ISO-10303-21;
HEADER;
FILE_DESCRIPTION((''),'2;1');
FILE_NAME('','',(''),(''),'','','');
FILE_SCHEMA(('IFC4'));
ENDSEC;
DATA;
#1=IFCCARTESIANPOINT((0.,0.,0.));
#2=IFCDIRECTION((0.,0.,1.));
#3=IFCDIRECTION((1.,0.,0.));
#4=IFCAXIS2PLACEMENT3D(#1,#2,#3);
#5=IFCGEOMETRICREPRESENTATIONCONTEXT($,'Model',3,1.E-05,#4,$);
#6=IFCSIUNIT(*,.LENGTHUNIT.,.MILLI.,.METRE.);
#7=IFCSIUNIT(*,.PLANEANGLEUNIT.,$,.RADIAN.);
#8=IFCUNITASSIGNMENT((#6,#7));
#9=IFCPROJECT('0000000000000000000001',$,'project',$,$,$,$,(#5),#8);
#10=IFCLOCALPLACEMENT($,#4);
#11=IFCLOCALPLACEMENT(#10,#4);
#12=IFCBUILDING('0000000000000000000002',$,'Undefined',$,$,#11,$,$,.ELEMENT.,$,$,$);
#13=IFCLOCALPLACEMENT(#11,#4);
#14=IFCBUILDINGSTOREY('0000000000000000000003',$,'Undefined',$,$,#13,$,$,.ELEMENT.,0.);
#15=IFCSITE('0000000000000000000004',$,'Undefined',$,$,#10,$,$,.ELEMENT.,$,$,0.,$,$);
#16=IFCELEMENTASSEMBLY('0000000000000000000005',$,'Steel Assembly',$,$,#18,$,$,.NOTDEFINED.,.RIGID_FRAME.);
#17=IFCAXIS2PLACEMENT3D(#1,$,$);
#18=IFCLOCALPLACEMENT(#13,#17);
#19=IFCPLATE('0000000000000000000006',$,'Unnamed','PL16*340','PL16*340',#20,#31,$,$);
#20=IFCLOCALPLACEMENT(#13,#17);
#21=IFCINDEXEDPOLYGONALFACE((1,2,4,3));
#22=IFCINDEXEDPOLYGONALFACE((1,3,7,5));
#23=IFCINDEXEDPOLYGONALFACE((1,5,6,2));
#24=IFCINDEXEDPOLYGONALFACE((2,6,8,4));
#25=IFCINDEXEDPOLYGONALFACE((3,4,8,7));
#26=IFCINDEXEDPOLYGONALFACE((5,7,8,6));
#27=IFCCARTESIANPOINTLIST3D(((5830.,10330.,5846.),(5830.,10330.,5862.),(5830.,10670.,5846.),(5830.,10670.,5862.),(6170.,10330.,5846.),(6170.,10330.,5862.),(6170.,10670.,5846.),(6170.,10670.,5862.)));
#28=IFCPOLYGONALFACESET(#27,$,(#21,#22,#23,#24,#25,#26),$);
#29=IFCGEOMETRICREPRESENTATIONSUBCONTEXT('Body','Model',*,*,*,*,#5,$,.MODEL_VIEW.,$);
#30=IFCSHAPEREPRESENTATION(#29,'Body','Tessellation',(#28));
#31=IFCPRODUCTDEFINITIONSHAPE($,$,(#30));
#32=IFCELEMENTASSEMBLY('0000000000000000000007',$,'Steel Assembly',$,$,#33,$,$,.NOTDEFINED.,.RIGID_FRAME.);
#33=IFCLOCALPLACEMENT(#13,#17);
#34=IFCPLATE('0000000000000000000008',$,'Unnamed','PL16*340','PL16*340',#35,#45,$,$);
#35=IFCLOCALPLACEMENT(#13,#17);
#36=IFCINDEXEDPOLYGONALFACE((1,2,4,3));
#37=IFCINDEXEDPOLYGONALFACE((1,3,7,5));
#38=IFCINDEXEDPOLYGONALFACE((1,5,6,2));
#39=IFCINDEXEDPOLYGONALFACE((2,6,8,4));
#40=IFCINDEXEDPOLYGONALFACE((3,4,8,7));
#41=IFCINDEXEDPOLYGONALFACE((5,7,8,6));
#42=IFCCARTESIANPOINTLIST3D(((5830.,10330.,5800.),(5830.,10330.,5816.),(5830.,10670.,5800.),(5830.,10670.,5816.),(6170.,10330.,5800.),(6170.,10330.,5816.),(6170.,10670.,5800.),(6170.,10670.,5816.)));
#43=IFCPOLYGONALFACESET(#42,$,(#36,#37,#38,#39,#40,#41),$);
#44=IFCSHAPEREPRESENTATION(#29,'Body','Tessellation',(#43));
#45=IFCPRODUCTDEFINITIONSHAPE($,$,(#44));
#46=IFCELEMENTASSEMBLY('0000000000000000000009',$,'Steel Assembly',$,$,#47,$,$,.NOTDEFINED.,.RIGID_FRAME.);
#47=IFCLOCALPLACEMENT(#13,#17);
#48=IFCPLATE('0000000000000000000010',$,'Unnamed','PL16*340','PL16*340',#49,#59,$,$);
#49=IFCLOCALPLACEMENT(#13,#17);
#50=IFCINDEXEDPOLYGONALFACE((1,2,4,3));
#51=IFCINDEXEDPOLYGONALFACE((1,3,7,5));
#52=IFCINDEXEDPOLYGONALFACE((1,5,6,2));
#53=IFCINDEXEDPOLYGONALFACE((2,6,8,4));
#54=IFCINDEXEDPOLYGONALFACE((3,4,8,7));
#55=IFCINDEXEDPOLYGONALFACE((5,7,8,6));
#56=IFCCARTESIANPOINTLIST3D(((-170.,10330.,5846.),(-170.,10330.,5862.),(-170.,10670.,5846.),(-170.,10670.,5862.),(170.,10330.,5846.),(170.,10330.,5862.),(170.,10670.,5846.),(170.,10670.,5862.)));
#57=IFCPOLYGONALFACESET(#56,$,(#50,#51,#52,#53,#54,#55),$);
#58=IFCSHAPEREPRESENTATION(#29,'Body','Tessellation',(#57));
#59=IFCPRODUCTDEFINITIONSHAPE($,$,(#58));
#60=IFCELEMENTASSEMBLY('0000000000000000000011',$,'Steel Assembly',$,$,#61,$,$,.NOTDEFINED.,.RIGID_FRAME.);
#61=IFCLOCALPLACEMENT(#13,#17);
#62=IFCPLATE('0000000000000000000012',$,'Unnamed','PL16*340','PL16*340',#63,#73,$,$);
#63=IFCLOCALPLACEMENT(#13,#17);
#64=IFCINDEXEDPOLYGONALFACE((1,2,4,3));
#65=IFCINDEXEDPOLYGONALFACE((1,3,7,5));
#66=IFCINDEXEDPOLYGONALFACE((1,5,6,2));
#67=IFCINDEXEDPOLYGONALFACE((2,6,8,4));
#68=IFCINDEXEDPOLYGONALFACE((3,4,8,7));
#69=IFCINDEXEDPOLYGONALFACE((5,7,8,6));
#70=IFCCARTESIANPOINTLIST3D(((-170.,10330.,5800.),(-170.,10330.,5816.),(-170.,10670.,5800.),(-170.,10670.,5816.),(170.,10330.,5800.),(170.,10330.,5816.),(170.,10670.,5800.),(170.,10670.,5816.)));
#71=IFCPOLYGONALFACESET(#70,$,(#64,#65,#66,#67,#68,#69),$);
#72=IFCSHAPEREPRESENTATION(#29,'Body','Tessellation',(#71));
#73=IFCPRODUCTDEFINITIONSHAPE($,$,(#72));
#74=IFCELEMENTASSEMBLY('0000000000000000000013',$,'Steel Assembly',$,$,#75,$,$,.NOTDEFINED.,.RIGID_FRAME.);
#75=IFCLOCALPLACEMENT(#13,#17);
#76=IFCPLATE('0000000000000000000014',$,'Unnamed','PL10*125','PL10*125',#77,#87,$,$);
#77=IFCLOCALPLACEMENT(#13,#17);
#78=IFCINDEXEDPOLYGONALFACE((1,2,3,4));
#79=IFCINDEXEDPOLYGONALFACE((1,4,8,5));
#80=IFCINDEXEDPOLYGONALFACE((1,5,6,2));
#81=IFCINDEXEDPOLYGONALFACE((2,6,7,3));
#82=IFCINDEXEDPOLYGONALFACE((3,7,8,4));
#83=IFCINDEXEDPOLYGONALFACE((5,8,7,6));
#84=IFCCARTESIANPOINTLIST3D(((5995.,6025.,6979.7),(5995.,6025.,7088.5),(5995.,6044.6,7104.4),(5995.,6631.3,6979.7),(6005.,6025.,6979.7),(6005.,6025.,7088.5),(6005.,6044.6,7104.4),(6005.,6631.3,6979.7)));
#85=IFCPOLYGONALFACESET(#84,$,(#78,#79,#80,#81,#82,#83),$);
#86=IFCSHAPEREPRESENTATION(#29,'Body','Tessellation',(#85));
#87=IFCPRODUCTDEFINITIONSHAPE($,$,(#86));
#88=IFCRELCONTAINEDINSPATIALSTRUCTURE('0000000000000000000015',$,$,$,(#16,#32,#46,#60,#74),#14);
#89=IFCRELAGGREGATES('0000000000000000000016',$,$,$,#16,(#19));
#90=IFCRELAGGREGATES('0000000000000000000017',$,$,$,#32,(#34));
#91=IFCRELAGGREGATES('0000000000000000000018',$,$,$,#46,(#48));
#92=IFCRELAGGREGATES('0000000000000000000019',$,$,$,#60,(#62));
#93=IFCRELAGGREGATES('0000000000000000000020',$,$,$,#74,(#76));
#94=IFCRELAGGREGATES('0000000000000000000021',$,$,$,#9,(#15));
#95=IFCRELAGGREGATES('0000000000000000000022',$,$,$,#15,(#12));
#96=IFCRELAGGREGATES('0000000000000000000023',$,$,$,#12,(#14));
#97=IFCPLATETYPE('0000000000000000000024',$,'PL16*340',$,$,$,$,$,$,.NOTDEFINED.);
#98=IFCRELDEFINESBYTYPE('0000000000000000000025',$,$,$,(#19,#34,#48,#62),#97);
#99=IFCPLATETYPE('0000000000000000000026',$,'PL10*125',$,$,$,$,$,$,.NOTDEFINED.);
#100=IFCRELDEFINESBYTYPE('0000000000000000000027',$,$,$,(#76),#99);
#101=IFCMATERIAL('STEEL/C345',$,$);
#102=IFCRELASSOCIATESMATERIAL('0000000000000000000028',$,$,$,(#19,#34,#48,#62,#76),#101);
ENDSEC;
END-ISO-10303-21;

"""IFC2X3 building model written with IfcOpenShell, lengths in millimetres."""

from ifc_helpers import new_model, si_unit, frame, origin_with_axes, place, context, subcontext, project, spatial, polyline, outline, extrude, material, type_object, element, aggregate, save


model = new_model("IFC2X3")

# Units and contexts
model_context = context("Model", 3, precision=1e-05, world=origin_with_axes())
body_context = subcontext(model_context, "Body", "Model", "MODEL_VIEW")
ifc_project = project(units=[si_unit("LENGTHUNIT", "METRE", prefix="MILLI"), si_unit("PLANEANGLEUNIT", "RADIAN")], contexts=[model_context])

# Site, building, storey
site_placement = place(None, origin_with_axes())
site = spatial("IfcSite", under=ifc_project, at=site_placement, Name="Undefined", CompositionType="ELEMENT", RefElevation=0.0)
building_placement = place(site_placement, origin_with_axes())
building = spatial("IfcBuilding", under=site, at=building_placement, Name="Undefined", CompositionType="ELEMENT")
storey_placement = place(building_placement, origin_with_axes())
storey = spatial("IfcBuildingStorey", under=building, at=storey_placement, Name="Undefined", CompositionType="ELEMENT", Elevation=0.0)

# Shared definitions
ifc_material_1 = material(Name="STEEL/C345")

# Element assemblies, plates
assembly_1_placement = place(storey_placement, origin_with_axes())
assembly_1 = element("IfcElementAssembly", 1, at=assembly_1_placement, inside=storey, Name="Steel Assembly", AssemblyPlace="NOTDEFINED", PredefinedType="RIGID_FRAME")
plate_type_1 = type_object("IfcPlateType", Name="PL16*340", PredefinedType="NOTDEFINED")
plate_1_placement = place(assembly_1_placement, frame((5830.0, 10330.0, 5854.0), z_axis=(0.0, 0.0, -1.0), x_axis=(0.0, 1.0, 0.0)))
plate_1 = element("IfcPlate", 2, at=plate_1_placement, type_object=plate_type_1, material=ifc_material_1, Name="Unnamed", Description="PL16*340", ObjectType="PL16*340", context=body_context, shape_type="SweptSolid", body=[
    extrude(outline(polyline([(0.0, 0.0), (340.0, 0.0), (340.0, 340.0), (0.0, 340.0), (0.0, 0.0)])), frame((0.0, 0.0, -8.0), z_axis=(0.0, 0.0, 1.0), x_axis=(1.0, 0.0, 0.0)), (0.0, 0.0, 1.0), 16.0),
])
aggregate(assembly_1, [plate_1])
assembly_2_placement = place(storey_placement, origin_with_axes())
assembly_2 = element("IfcElementAssembly", 3, at=assembly_2_placement, inside=storey, Name="Steel Assembly", AssemblyPlace="NOTDEFINED", PredefinedType="RIGID_FRAME")
plate_2_placement = place(assembly_2_placement, frame((5830.0, 10330.0, 5808.0), z_axis=(0.0, 0.0, -1.0), x_axis=(0.0, 1.0, 0.0)))
plate_2 = element("IfcPlate", 4, at=plate_2_placement, type_object=plate_type_1, material=ifc_material_1, Name="Unnamed", Description="PL16*340", ObjectType="PL16*340", context=body_context, shape_type="SweptSolid", body=[
    extrude(outline(polyline([(0.0, 0.0), (340.0, 0.0), (340.0, 340.0), (0.0, 340.0), (0.0, 0.0)])), frame((0.0, 0.0, -8.0), z_axis=(0.0, 0.0, 1.0), x_axis=(1.0, 0.0, 0.0)), (0.0, 0.0, 1.0), 16.0),
])
aggregate(assembly_2, [plate_2])
assembly_3_placement = place(storey_placement, origin_with_axes())
assembly_3 = element("IfcElementAssembly", 5, at=assembly_3_placement, inside=storey, Name="Steel Assembly", AssemblyPlace="NOTDEFINED", PredefinedType="RIGID_FRAME")
plate_3_placement = place(assembly_3_placement, frame((-170.0, 10330.0, 5854.0), z_axis=(0.0, 0.0, -1.0), x_axis=(0.0, 1.0, 0.0)))
plate_3 = element("IfcPlate", 6, at=plate_3_placement, type_object=plate_type_1, material=ifc_material_1, Name="Unnamed", Description="PL16*340", ObjectType="PL16*340", context=body_context, shape_type="SweptSolid", body=[
    extrude(outline(polyline([(0.0, 0.0), (340.0, 0.0), (340.0, 340.0), (0.0, 340.0), (0.0, 0.0)])), frame((0.0, 0.0, -8.0), z_axis=(0.0, 0.0, 1.0), x_axis=(1.0, 0.0, 0.0)), (0.0, 0.0, 1.0), 16.0),
])
aggregate(assembly_3, [plate_3])
assembly_4_placement = place(storey_placement, origin_with_axes())
assembly_4 = element("IfcElementAssembly", 7, at=assembly_4_placement, inside=storey, Name="Steel Assembly", AssemblyPlace="NOTDEFINED", PredefinedType="RIGID_FRAME")
plate_4_placement = place(assembly_4_placement, frame((-170.0, 10330.0, 5808.0), z_axis=(0.0, 0.0, -1.0), x_axis=(0.0, 1.0, 0.0)))
plate_4 = element("IfcPlate", 8, at=plate_4_placement, type_object=plate_type_1, material=ifc_material_1, Name="Unnamed", Description="PL16*340", ObjectType="PL16*340", context=body_context, shape_type="SweptSolid", body=[
    extrude(outline(polyline([(0.0, 0.0), (340.0, 0.0), (340.0, 340.0), (0.0, 340.0), (0.0, 0.0)])), frame((0.0, 0.0, -8.0), z_axis=(0.0, 0.0, 1.0), x_axis=(1.0, 0.0, 0.0)), (0.0, 0.0, 1.0), 16.0),
])
aggregate(assembly_4, [plate_4])
assembly_5_placement = place(storey_placement, origin_with_axes())
assembly_5 = element("IfcElementAssembly", 9, at=assembly_5_placement, inside=storey, Name="Steel Assembly", AssemblyPlace="NOTDEFINED", PredefinedType="RIGID_FRAME")
plate_type_2 = type_object("IfcPlateType", Name="PL10*125", PredefinedType="NOTDEFINED")
plate_5_placement = place(assembly_5_placement, frame((6000.0, 6631.3, 6979.7), z_axis=(-1.0, 0.0, 0.0), x_axis=(0.0, -1.0, 0.0)))
plate_5 = element("IfcPlate", 10, at=plate_5_placement, type_object=plate_type_2, material=ifc_material_1, Name="Unnamed", Description="PL10*125", ObjectType="PL10*125", context=body_context, shape_type="SweptSolid", body=[
    extrude(outline(polyline([(0.0, 0.0), (606.3, 0.0), (606.3, 108.8), (586.7, 124.7), (0.0, 0.0)])), frame((0.0, 0.0, -5.0), z_axis=(0.0, 0.0, 1.0), x_axis=(1.0, 0.0, 0.0)), (0.0, 0.0, 1.0), 10.0),
])
aggregate(assembly_5, [plate_5])

save(model, "model.ifc")
